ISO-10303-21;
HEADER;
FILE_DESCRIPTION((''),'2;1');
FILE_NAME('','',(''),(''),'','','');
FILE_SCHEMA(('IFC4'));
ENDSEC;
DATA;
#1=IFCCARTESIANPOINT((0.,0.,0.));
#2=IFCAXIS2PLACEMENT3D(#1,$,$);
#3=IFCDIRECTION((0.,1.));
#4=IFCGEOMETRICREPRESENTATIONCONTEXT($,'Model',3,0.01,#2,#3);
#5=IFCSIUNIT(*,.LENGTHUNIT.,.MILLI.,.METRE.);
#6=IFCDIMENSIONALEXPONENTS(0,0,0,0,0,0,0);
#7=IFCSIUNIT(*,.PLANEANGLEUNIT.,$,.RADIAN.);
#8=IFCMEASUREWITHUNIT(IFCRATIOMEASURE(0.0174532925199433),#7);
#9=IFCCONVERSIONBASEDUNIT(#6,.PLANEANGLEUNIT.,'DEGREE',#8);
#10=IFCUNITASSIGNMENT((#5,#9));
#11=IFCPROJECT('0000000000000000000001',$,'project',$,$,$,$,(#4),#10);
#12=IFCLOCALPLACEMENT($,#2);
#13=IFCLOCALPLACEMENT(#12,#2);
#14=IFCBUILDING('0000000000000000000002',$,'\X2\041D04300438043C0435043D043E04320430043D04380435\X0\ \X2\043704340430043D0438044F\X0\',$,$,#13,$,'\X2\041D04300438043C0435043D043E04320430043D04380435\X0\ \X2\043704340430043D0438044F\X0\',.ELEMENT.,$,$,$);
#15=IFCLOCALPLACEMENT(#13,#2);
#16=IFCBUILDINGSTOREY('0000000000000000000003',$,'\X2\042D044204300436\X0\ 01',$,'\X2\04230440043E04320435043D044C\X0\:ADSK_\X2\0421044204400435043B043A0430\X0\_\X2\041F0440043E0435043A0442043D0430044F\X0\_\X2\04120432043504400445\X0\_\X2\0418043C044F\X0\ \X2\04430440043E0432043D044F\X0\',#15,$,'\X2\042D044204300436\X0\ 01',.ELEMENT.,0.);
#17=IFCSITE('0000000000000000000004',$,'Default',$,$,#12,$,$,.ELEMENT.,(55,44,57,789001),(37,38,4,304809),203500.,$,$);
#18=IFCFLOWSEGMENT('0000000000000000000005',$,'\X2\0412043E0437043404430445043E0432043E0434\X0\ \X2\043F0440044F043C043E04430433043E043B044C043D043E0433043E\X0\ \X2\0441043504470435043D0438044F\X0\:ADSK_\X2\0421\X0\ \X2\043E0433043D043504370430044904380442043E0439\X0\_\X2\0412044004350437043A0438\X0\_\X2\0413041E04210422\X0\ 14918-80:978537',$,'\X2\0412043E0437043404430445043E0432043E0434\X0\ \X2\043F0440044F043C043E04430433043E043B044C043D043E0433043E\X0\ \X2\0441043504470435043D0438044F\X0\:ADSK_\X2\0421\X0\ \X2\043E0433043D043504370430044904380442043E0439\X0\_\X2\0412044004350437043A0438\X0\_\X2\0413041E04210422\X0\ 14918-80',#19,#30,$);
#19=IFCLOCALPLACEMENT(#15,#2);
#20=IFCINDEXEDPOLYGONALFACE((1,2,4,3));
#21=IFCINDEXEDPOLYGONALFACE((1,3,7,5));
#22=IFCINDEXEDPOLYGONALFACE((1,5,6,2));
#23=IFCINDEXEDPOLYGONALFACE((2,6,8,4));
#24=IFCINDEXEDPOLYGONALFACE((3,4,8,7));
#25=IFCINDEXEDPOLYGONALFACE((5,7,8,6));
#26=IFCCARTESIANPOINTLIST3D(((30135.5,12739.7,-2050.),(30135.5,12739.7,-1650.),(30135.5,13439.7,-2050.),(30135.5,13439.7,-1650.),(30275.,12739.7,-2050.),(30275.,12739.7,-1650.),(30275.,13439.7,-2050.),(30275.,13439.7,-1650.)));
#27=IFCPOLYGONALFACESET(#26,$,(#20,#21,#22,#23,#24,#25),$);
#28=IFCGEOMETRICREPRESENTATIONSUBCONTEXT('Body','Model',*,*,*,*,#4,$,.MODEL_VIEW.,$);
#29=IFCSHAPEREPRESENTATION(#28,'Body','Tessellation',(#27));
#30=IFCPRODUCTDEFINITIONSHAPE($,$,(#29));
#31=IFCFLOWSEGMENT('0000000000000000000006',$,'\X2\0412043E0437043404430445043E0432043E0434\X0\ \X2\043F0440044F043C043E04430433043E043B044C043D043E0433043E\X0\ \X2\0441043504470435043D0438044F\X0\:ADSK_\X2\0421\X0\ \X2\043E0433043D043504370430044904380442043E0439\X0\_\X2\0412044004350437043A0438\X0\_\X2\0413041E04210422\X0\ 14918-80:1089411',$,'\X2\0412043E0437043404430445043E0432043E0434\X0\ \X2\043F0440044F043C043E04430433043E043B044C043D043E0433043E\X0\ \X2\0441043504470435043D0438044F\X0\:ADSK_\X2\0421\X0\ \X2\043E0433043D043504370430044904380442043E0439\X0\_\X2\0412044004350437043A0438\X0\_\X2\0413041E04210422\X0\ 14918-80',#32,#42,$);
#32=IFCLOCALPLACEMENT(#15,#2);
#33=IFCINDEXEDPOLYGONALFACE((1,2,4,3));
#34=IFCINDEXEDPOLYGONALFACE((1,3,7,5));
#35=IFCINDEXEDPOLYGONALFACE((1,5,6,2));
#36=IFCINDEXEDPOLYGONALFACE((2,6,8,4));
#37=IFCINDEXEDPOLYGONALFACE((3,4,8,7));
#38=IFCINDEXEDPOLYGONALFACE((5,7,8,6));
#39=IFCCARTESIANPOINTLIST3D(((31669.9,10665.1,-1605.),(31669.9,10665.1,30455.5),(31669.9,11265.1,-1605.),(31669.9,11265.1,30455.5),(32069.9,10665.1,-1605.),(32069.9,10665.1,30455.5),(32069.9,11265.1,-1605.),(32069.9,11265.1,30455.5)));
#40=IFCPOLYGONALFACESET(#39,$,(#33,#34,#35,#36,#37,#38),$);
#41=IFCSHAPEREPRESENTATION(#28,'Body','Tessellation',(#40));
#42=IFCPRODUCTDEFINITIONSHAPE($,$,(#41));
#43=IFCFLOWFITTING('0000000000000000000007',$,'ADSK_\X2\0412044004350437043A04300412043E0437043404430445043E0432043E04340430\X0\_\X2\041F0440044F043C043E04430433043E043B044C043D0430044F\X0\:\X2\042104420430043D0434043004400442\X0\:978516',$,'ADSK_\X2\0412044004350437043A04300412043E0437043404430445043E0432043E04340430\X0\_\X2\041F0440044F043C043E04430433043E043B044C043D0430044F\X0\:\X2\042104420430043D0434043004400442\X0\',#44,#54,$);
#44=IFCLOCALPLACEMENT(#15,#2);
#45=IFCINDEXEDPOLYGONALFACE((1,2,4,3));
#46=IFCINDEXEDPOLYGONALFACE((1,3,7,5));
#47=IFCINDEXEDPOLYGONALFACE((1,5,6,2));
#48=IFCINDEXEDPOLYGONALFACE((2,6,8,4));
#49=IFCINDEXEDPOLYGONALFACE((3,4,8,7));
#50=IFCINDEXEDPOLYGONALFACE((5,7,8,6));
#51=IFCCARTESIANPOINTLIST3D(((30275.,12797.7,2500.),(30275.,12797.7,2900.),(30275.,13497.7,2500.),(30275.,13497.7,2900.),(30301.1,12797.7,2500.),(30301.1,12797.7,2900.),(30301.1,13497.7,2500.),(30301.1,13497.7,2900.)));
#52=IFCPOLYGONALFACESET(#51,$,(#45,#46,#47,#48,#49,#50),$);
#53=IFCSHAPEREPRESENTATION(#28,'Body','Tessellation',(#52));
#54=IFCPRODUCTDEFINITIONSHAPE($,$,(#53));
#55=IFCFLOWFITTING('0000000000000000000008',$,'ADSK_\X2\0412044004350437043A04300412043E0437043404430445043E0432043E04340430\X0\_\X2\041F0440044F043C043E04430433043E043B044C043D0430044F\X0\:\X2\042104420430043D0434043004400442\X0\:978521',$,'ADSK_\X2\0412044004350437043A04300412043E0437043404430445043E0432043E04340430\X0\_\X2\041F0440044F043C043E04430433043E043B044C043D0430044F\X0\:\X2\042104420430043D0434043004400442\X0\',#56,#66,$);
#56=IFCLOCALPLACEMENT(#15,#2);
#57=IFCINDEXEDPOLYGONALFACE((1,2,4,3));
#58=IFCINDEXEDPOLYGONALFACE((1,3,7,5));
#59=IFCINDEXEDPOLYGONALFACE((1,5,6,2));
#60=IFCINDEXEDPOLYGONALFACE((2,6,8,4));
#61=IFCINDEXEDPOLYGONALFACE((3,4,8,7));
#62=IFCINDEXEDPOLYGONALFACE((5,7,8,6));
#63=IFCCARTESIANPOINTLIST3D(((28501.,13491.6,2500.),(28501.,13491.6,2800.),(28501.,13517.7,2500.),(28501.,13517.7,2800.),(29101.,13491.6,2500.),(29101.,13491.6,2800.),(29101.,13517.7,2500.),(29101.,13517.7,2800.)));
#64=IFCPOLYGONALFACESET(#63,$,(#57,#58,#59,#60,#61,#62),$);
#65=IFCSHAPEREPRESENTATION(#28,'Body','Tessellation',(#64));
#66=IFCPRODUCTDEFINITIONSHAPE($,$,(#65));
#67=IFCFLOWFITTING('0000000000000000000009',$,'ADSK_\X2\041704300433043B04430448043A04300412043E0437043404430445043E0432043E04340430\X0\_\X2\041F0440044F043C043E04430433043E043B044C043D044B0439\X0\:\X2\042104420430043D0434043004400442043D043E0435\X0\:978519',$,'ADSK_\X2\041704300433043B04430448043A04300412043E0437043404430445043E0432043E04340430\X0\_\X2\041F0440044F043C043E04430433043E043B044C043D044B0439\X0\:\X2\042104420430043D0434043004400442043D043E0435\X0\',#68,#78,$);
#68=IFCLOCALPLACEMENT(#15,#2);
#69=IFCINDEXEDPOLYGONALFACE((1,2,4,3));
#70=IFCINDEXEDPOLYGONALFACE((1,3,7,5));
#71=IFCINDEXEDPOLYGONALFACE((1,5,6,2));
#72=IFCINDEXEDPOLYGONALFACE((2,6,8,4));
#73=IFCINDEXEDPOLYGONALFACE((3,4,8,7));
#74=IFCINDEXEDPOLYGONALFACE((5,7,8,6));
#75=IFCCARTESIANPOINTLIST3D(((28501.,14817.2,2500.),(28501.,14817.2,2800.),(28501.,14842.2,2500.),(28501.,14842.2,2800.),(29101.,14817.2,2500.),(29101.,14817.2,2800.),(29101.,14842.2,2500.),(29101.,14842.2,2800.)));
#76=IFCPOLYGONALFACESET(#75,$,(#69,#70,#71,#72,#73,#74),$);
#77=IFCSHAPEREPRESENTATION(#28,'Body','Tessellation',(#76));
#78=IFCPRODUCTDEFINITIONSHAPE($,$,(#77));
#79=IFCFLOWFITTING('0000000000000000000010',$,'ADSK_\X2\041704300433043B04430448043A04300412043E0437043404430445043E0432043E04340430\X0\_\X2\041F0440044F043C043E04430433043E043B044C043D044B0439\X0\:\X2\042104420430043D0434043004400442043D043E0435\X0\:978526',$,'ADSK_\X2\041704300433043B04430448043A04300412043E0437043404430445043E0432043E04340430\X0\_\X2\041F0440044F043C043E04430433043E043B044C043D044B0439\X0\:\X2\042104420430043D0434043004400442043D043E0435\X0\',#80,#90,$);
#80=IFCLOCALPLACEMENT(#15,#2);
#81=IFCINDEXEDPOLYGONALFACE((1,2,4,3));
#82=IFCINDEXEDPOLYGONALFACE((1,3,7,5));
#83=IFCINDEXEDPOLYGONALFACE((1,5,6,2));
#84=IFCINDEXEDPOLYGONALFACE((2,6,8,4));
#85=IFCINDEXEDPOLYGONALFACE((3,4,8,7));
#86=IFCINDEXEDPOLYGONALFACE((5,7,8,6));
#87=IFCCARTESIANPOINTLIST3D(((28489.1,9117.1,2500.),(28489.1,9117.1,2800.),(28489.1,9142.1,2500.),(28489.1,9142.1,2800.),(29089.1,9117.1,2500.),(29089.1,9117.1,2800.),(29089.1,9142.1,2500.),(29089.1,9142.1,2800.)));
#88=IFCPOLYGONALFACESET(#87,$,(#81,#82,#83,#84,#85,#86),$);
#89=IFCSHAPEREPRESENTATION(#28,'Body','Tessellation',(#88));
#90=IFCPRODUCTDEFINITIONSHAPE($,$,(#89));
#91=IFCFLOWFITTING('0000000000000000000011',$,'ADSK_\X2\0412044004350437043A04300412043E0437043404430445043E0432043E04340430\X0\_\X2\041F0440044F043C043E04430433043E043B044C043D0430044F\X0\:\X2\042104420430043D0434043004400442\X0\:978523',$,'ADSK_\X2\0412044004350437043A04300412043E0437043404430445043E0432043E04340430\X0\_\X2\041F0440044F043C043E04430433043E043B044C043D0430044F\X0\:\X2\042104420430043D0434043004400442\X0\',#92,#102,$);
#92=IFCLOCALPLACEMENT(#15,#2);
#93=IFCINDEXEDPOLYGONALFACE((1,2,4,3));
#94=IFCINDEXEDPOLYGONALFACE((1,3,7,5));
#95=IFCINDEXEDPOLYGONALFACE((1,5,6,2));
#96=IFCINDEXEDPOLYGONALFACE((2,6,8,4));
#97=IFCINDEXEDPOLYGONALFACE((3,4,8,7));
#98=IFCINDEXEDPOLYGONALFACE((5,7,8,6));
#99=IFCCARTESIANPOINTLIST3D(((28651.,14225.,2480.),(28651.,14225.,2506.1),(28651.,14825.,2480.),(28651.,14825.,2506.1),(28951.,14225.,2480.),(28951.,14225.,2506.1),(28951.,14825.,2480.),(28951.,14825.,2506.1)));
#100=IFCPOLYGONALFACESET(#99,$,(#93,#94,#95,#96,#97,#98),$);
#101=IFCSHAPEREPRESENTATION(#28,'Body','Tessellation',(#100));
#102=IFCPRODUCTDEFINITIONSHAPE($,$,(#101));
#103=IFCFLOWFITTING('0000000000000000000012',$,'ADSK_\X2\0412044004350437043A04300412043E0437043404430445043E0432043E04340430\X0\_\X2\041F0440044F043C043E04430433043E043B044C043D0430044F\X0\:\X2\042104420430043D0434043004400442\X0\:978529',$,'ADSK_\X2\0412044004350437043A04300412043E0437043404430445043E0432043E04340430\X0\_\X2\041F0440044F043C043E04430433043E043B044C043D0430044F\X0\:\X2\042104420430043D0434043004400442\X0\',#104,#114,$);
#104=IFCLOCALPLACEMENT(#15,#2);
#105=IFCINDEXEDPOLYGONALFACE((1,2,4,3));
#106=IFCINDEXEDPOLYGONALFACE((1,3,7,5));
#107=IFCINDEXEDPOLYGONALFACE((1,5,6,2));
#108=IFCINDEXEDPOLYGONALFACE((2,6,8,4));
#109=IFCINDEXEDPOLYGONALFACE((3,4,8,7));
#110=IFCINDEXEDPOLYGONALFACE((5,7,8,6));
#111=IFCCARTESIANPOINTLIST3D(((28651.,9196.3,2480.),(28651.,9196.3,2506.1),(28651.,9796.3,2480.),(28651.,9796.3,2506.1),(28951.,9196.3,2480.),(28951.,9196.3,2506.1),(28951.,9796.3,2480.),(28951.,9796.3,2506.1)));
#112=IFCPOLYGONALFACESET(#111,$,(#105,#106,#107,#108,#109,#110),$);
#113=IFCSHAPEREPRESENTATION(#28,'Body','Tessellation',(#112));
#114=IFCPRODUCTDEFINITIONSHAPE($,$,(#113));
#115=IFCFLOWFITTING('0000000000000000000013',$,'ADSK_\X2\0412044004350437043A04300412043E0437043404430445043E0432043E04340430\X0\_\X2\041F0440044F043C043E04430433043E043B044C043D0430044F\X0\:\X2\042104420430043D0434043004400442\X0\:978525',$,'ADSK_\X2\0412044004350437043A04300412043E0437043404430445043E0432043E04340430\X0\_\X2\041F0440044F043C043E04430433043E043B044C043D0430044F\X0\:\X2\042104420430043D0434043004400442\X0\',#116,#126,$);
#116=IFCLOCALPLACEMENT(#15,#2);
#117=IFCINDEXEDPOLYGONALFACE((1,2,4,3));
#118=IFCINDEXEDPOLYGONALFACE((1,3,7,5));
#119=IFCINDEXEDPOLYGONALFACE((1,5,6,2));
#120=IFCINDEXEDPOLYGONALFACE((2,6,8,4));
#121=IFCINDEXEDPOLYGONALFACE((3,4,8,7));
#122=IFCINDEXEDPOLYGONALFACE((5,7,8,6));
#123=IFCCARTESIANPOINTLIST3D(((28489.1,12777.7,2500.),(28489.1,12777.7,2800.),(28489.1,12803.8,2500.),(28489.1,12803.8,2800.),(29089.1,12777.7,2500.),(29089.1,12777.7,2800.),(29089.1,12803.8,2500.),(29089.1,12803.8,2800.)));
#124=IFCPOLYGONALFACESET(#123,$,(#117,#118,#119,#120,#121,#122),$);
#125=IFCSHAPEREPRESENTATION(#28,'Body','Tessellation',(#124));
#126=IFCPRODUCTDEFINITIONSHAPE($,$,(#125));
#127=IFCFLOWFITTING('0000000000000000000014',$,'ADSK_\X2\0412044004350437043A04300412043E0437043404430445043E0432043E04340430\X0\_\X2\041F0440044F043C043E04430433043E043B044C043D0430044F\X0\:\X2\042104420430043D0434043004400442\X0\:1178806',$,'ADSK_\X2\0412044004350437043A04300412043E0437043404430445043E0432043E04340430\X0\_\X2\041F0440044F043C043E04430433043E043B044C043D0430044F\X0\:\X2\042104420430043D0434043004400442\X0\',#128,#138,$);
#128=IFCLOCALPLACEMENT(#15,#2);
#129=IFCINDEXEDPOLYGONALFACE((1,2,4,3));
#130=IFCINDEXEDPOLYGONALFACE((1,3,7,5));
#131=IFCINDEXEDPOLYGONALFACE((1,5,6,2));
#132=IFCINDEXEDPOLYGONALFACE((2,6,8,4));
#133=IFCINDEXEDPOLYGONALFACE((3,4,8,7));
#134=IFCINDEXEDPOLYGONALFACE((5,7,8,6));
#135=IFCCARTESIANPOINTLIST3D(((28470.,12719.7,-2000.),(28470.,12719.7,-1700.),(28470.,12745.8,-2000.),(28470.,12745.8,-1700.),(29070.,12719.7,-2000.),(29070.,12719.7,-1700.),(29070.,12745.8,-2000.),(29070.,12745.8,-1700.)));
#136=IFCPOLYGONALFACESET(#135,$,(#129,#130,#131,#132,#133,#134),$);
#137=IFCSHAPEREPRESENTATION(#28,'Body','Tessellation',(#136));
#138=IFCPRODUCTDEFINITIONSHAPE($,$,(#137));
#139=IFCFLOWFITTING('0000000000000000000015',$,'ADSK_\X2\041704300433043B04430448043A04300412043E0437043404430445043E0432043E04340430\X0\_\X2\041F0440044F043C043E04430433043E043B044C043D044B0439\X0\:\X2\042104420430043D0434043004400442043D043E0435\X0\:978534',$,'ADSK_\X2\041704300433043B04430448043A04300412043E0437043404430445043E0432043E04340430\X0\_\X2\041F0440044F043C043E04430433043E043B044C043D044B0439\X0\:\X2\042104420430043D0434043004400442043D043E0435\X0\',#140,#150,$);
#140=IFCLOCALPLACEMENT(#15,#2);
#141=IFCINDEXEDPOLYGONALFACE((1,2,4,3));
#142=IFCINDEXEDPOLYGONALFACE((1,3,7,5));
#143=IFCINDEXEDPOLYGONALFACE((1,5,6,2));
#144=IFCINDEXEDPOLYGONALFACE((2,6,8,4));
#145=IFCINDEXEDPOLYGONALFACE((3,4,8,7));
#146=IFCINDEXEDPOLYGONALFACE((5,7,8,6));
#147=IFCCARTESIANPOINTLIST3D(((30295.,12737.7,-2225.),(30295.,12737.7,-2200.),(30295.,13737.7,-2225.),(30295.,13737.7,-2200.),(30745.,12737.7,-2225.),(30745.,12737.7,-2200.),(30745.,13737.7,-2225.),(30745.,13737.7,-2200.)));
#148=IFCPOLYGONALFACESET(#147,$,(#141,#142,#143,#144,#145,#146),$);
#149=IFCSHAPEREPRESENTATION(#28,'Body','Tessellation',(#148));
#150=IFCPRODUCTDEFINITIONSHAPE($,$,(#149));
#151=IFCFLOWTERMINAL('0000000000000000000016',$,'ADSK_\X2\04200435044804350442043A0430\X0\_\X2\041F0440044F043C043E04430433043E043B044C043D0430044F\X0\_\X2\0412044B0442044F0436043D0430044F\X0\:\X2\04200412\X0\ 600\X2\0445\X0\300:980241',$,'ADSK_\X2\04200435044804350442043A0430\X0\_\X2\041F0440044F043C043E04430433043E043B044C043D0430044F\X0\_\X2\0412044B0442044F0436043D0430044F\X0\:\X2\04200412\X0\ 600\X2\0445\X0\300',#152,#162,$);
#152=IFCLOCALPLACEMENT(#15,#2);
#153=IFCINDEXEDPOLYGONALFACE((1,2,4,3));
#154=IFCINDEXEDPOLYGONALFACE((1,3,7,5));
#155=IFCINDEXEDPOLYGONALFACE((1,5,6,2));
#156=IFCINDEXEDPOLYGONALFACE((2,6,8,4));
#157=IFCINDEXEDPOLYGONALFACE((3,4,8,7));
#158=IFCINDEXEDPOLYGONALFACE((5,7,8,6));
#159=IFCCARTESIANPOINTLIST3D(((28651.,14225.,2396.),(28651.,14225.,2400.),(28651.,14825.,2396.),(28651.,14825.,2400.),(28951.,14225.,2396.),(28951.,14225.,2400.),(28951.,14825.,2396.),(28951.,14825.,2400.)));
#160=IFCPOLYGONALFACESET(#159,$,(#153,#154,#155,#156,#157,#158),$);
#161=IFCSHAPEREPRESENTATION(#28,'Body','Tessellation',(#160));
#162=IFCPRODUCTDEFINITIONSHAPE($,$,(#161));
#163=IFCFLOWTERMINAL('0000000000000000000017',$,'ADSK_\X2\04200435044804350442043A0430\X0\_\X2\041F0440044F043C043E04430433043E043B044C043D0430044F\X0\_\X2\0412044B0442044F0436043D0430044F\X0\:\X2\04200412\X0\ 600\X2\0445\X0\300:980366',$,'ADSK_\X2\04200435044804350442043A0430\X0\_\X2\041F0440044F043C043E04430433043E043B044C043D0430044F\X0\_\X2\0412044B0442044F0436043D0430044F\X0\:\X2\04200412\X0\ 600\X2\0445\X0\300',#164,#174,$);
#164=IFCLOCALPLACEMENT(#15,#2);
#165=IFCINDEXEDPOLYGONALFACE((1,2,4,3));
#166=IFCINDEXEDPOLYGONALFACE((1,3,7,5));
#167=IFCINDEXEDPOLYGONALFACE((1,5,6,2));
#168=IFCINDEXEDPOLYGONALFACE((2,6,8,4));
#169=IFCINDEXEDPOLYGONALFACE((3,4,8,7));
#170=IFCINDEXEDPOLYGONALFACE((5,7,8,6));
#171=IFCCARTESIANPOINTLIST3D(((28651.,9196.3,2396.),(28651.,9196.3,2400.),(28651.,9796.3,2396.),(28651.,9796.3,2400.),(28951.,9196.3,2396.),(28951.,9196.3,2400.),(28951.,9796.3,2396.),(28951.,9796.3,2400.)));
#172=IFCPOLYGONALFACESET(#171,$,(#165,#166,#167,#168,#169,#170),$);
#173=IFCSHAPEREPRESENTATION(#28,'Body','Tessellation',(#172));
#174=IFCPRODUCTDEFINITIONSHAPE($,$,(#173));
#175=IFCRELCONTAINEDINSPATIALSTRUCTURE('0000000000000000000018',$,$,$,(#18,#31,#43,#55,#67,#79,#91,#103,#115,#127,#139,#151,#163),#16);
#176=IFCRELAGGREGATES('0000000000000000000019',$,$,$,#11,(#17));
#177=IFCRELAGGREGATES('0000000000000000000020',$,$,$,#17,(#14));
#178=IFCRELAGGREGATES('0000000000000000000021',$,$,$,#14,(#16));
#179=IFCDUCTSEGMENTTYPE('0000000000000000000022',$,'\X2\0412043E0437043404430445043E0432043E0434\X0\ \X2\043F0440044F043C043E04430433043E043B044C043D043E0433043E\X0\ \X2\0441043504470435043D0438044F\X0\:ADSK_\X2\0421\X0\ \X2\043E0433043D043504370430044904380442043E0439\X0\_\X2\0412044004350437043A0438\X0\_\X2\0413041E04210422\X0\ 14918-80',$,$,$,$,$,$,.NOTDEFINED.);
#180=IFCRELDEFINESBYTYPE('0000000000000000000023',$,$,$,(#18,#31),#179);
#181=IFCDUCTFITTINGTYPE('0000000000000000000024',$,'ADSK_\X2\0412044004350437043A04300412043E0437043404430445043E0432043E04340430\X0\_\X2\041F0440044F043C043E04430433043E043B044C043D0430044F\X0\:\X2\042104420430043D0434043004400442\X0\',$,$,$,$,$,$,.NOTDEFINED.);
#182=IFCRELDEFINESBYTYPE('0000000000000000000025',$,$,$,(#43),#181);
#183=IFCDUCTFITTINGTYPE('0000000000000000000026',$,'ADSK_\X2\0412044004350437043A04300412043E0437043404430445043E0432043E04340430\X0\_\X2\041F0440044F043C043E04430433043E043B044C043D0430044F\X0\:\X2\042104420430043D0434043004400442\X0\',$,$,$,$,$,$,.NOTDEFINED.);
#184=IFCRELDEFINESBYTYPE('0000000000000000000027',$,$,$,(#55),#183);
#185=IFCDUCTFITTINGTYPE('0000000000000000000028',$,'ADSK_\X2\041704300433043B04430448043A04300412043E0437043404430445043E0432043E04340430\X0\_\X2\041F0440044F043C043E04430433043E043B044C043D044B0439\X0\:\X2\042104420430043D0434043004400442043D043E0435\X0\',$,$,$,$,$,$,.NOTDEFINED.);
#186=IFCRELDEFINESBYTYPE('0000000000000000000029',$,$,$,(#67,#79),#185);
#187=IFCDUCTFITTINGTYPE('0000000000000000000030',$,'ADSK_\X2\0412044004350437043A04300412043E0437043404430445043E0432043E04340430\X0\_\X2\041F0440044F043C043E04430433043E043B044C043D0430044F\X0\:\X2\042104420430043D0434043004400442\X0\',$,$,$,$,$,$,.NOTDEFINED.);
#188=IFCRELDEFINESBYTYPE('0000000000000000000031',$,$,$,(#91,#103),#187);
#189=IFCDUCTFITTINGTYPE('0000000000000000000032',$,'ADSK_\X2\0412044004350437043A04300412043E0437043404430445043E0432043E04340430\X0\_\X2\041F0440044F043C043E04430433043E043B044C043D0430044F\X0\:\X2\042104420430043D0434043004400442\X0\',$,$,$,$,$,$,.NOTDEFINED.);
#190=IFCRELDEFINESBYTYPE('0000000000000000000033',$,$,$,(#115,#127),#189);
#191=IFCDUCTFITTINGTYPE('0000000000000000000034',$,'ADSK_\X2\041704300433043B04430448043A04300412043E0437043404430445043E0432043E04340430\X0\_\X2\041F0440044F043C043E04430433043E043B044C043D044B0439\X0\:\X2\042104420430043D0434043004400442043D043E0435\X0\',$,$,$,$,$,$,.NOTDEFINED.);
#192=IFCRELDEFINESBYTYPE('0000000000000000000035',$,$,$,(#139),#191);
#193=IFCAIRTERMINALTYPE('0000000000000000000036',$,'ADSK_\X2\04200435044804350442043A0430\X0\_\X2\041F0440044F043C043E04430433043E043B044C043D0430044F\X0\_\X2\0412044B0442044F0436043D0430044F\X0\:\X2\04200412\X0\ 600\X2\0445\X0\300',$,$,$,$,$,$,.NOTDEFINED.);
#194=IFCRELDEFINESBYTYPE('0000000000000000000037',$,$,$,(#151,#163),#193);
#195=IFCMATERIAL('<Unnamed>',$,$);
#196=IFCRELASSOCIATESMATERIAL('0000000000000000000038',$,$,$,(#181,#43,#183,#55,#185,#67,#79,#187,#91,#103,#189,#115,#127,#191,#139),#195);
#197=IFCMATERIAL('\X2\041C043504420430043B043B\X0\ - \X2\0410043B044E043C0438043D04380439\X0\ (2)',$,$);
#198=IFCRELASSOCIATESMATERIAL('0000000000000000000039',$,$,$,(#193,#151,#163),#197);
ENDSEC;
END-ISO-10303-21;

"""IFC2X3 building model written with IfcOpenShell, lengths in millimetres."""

from ifc_helpers import new_model, entity, si_unit, converted_unit, direction, frame, origin, origin_2d_with_axis, place, context, subcontext, project, spatial, rectangle, extrude, source, transform, mapped, material, type_object, type_shapes, element, save


model = new_model("IFC2X3")

# Units and contexts
model_context = context("Model", 3, precision=0.01, world=origin(), true_north=direction((0.0, 1.0)))
body_context = subcontext(model_context, "Body", "Model", "MODEL_VIEW")
ifc_project = project(units=[si_unit("LENGTHUNIT", "METRE", prefix="MILLI"), converted_unit("PLANEANGLEUNIT", "DEGREE", entity("IfcRatioMeasure", 0.0174532925199433), si_unit("PLANEANGLEUNIT", "RADIAN"), dimensions=[0, 0, 0, 0, 0, 0, 0])], contexts=[model_context])

# Site, building, storey
site_placement = place(None, origin())
site = spatial("IfcSite", under=ifc_project, at=site_placement, Name="Default", CompositionType="ELEMENT", RefLatitude=(55, 44, 57, 789001), RefLongitude=(37, 38, 4, 304809), RefElevation=203500.0)
building_placement = place(site_placement, origin())
building = spatial("IfcBuilding", under=site, at=building_placement, Name="Наименование здания", LongName="Наименование здания", CompositionType="ELEMENT")
storey_placement = place(building_placement, origin())
storey = spatial("IfcBuildingStorey", under=building, at=storey_placement, Name="Этаж 01", ObjectType="Уровень:ADSK_Стрелка_Проектная_Вверх_Имя уровня", LongName="Этаж 01", CompositionType="ELEMENT", Elevation=0.0)

# Flow segments
duct_segment_type = type_object("IfcDuctSegmentType", Name="Воздуховод прямоугольного сечения:ADSK_С огнезащитой_Врезки_ГОСТ 14918-80", PredefinedType="NOTDEFINED")
flow_segment_1_placement = place(storey_placement, frame((30135.5, 12739.7, -2050.0)))
element("IfcFlowSegment", 1, at=flow_segment_1_placement, inside=storey, type_object=duct_segment_type, Name="Воздуховод прямоугольного сечения:ADSK_С огнезащитой_Врезки_ГОСТ 14918-80:978537", ObjectType="Воздуховод прямоугольного сечения:ADSK_С огнезащитой_Врезки_ГОСТ 14918-80", context=body_context, shape_type="SweptSolid", body=[
    extrude(rectangle(XDim=139.5, YDim=700.0, at=origin_2d_with_axis()), frame((69.7, 350.0, 0.0)), (0.0, 0.0, 1.0), 400.0),
])
flow_segment_2_placement = place(storey_placement, frame((31669.9, 10665.1, -1605.0)))
element("IfcFlowSegment", 2, at=flow_segment_2_placement, inside=storey, type_object=duct_segment_type, Name="Воздуховод прямоугольного сечения:ADSK_С огнезащитой_Врезки_ГОСТ 14918-80:1089411", ObjectType="Воздуховод прямоугольного сечения:ADSK_С огнезащитой_Врезки_ГОСТ 14918-80", context=body_context, shape_type="SweptSolid", body=[
    extrude(rectangle(XDim=600.0, YDim=400.0, at=origin_2d_with_axis()), frame((200.0, 300.0, 0.0), z_axis=(0.0, 0.0, 1.0), x_axis=(0.0, -1.0, 0.0)), (0.0, 0.0, 1.0), 32060.5),
])

# Flow fittings
ifc_material_1 = material(Name="<Unnamed>")
duct_fitting_type_1 = type_object("IfcDuctFittingType", Name="ADSK_ВрезкаВоздуховода_Прямоугольная:Стандарт", PredefinedType="NOTDEFINED", material=ifc_material_1)
shared_shape_1 = source(origin(), body_context, "Body", "SweptSolid", [
    extrude(rectangle(XDim=26.1, YDim=400.0, at=origin_2d_with_axis()), frame((7.0, 0.0, -350.0)), (0.0, 0.0, 1.0), 700.0),
])
type_shapes(duct_fitting_type_1, [shared_shape_1])
flow_fitting_1_placement = place(storey_placement, frame((30295.0, 13147.7, 2700.0), z_axis=(0.0, 1.0, 0.0), x_axis=(-1.0, 0.0, 0.0)))
element("IfcFlowFitting", 3, at=flow_fitting_1_placement, inside=storey, type_object=duct_fitting_type_1, material=ifc_material_1, Name="ADSK_ВрезкаВоздуховода_Прямоугольная:Стандарт:978516", ObjectType="ADSK_ВрезкаВоздуховода_Прямоугольная:Стандарт", context=body_context, shape_type="MappedRepresentation", body=[
    mapped(shared_shape_1, transform((0.0, 0.0, 0.0), scale=1.0)),
])
duct_fitting_type_2 = type_object("IfcDuctFittingType", Name="ADSK_ВрезкаВоздуховода_Прямоугольная:Стандарт", PredefinedType="NOTDEFINED", material=ifc_material_1)
shared_shape_2 = source(origin(), body_context, "Body", "SweptSolid", [
    extrude(rectangle(XDim=26.1, YDim=600.0, at=origin_2d_with_axis()), frame((7.0, 0.0, -150.0)), (0.0, 0.0, 1.0), 300.0),
])
type_shapes(duct_fitting_type_2, [shared_shape_2])
flow_fitting_2_placement = place(storey_placement, frame((28801.0, 13497.7, 2650.0), z_axis=(0.0, 0.0, -1.0), x_axis=(0.0, 1.0, 0.0)))
element("IfcFlowFitting", 4, at=flow_fitting_2_placement, inside=storey, type_object=duct_fitting_type_2, material=ifc_material_1, Name="ADSK_ВрезкаВоздуховода_Прямоугольная:Стандарт:978521", ObjectType="ADSK_ВрезкаВоздуховода_Прямоугольная:Стандарт", context=body_context, shape_type="MappedRepresentation", body=[
    mapped(shared_shape_2, transform((0.0, 0.0, 0.0), scale=1.0)),
])
duct_fitting_type_3 = type_object("IfcDuctFittingType", Name="ADSK_ЗаглушкаВоздуховода_Прямоугольный:Стандартное", PredefinedType="NOTDEFINED", material=ifc_material_1)
shared_shape_3 = source(origin(), body_context, "Body", "SweptSolid", [
    extrude(rectangle(XDim=25.0, YDim=600.0, at=origin_2d_with_axis()), frame((12.5, 0.0, -150.0)), (0.0, 0.0, 1.0), 300.0),
])
type_shapes(duct_fitting_type_3, [shared_shape_3])
for number, where, z_axis, x_axis, name in (
    (5, (28801.0, 14817.2, 2650.0), (0.0, 0.0, 1.0), (0.0, 1.0, 0.0), "ADSK_ЗаглушкаВоздуховода_Прямоугольный:Стандартное:978519"),
    (6, (28789.1, 9142.1, 2650.0), (0.0, 0.0, 1.0), (0.0, -1.0, 0.0), "ADSK_ЗаглушкаВоздуховода_Прямоугольный:Стандартное:978526"),
):
    element("IfcFlowFitting", number, at=place(storey_placement, frame(where, z_axis=z_axis, x_axis=x_axis)), inside=storey, type_object=duct_fitting_type_3, material=ifc_material_1, Name=name, ObjectType="ADSK_ЗаглушкаВоздуховода_Прямоугольный:Стандартное", context=body_context, shape_type="MappedRepresentation", body=[
        mapped(shared_shape_3, transform((0.0, 0.0, 0.0), scale=1.0)),
    ])
duct_fitting_type_4 = type_object("IfcDuctFittingType", Name="ADSK_ВрезкаВоздуховода_Прямоугольная:Стандарт", PredefinedType="NOTDEFINED", material=ifc_material_1)
shared_shape_4 = source(origin(), body_context, "Body", "SweptSolid", [
    extrude(rectangle(XDim=300.0, YDim=26.1, at=origin_2d_with_axis()), frame((7.0, 0.0, -300.0), z_axis=(0.0, 0.0, 1.0), x_axis=(0.0, -1.0, 0.0)), (0.0, 0.0, 1.0), 600.0),
])
type_shapes(duct_fitting_type_4, [shared_shape_4])
for number, where, z_axis, x_axis, name in (
    (7, (28801.0, 14525.0, 2500.0), (0.0, 1.0, 0.0), (0.0, 0.0, -1.0), "ADSK_ВрезкаВоздуховода_Прямоугольная:Стандарт:978523"),
    (8, (28801.0, 9496.3, 2500.0), (0.0, 1.0, 0.0), (0.0, 0.0, -1.0), "ADSK_ВрезкаВоздуховода_Прямоугольная:Стандарт:978529"),
):
    element("IfcFlowFitting", number, at=place(storey_placement, frame(where, z_axis=z_axis, x_axis=x_axis)), inside=storey, type_object=duct_fitting_type_4, material=ifc_material_1, Name=name, ObjectType="ADSK_ВрезкаВоздуховода_Прямоугольная:Стандарт", context=body_context, shape_type="MappedRepresentation", body=[
        mapped(shared_shape_4, transform((0.0, 0.0, 0.0), scale=1.0)),
    ])
duct_fitting_type_5 = type_object("IfcDuctFittingType", Name="ADSK_ВрезкаВоздуховода_Прямоугольная:Стандарт", PredefinedType="NOTDEFINED", material=ifc_material_1)
shared_shape_5 = source(origin(), body_context, "Body", "SweptSolid", [
    extrude(rectangle(XDim=600.0, YDim=26.1, at=origin_2d_with_axis()), frame((7.0, 0.0, -150.0), z_axis=(0.0, 0.0, 1.0), x_axis=(0.0, -1.0, 0.0)), (0.0, 0.0, 1.0), 300.0),
])
type_shapes(duct_fitting_type_5, [shared_shape_5])
for number, where, z_axis, x_axis, name in (
    (9, (28789.1, 12797.7, 2650.0), (0.0, 0.0, -1.0), (0.0, -1.0, 0.0), "ADSK_ВрезкаВоздуховода_Прямоугольная:Стандарт:978525"),
    (10, (28770.0, 12739.7, -1850.0), (0.0, 0.0, -1.0), (0.0, -1.0, 0.0), "ADSK_ВрезкаВоздуховода_Прямоугольная:Стандарт:1178806"),
):
    element("IfcFlowFitting", number, at=place(storey_placement, frame(where, z_axis=z_axis, x_axis=x_axis)), inside=storey, type_object=duct_fitting_type_5, material=ifc_material_1, Name=name, ObjectType="ADSK_ВрезкаВоздуховода_Прямоугольная:Стандарт", context=body_context, shape_type="MappedRepresentation", body=[
        mapped(shared_shape_5, transform((0.0, 0.0, 0.0), scale=1.0)),
    ])
duct_fitting_type_6 = type_object("IfcDuctFittingType", Name="ADSK_ЗаглушкаВоздуховода_Прямоугольный:Стандартное", PredefinedType="NOTDEFINED", material=ifc_material_1)
shared_shape_6 = source(origin(), body_context, "Body", "SweptSolid", [
    extrude(rectangle(XDim=25.0, YDim=1000.0, at=origin_2d_with_axis()), frame((12.5, 0.0, -225.0)), (0.0, 0.0, 1.0), 450.0),
])
type_shapes(duct_fitting_type_6, [shared_shape_6])
flow_fitting_3_placement = place(storey_placement, frame((30520.0, 13237.7, -2200.0), z_axis=(-1.0, 0.0, 0.0), x_axis=(0.0, 0.0, -1.0)))
element("IfcFlowFitting", 11, at=flow_fitting_3_placement, inside=storey, type_object=duct_fitting_type_6, material=ifc_material_1, Name="ADSK_ЗаглушкаВоздуховода_Прямоугольный:Стандартное:978534", ObjectType="ADSK_ЗаглушкаВоздуховода_Прямоугольный:Стандартное", context=body_context, shape_type="MappedRepresentation", body=[
    mapped(shared_shape_6, transform((0.0, 0.0, 0.0), scale=1.0)),
])

# Flow terminals
ifc_material_2 = material(Name="Металл - Алюминий (2)")
air_terminal_type = type_object("IfcAirTerminalType", Name="ADSK_Решетка_Прямоугольная_Вытяжная:РВ 600х300", PredefinedType="NOTDEFINED", material=ifc_material_2)
shared_shape_7 = source(origin(), body_context, "Body", "SweptSolid", [
    extrude(rectangle(XDim=4.0, YDim=600.0, at=origin_2d_with_axis()), frame((0.0, -2.0, -150.0), z_axis=(0.0, 0.0, 1.0), x_axis=(0.0, 1.0, 0.0)), (0.0, 0.0, 1.0), 300.0),
])
type_shapes(air_terminal_type, [shared_shape_7])
for number, where, z_axis, x_axis, name in (
    (12, (28801.0, 14525.0, 2400.0), (-1.0, 0.0, 0.0), (0.0, -1.0, 0.0), "ADSK_Решетка_Прямоугольная_Вытяжная:РВ 600х300:980241"),
    (13, (28801.0, 9496.3, 2400.0), (-1.0, 0.0, 0.0), (0.0, -1.0, 0.0), "ADSK_Решетка_Прямоугольная_Вытяжная:РВ 600х300:980366"),
):
    element("IfcFlowTerminal", number, at=place(storey_placement, frame(where, z_axis=z_axis, x_axis=x_axis)), inside=storey, type_object=air_terminal_type, material=ifc_material_2, Name=name, ObjectType="ADSK_Решетка_Прямоугольная_Вытяжная:РВ 600х300", context=body_context, shape_type="MappedRepresentation", body=[
        mapped(shared_shape_7, transform((0.0, 0.0, 0.0), scale=1.0)),
    ])

save(model, "model.ifc")
